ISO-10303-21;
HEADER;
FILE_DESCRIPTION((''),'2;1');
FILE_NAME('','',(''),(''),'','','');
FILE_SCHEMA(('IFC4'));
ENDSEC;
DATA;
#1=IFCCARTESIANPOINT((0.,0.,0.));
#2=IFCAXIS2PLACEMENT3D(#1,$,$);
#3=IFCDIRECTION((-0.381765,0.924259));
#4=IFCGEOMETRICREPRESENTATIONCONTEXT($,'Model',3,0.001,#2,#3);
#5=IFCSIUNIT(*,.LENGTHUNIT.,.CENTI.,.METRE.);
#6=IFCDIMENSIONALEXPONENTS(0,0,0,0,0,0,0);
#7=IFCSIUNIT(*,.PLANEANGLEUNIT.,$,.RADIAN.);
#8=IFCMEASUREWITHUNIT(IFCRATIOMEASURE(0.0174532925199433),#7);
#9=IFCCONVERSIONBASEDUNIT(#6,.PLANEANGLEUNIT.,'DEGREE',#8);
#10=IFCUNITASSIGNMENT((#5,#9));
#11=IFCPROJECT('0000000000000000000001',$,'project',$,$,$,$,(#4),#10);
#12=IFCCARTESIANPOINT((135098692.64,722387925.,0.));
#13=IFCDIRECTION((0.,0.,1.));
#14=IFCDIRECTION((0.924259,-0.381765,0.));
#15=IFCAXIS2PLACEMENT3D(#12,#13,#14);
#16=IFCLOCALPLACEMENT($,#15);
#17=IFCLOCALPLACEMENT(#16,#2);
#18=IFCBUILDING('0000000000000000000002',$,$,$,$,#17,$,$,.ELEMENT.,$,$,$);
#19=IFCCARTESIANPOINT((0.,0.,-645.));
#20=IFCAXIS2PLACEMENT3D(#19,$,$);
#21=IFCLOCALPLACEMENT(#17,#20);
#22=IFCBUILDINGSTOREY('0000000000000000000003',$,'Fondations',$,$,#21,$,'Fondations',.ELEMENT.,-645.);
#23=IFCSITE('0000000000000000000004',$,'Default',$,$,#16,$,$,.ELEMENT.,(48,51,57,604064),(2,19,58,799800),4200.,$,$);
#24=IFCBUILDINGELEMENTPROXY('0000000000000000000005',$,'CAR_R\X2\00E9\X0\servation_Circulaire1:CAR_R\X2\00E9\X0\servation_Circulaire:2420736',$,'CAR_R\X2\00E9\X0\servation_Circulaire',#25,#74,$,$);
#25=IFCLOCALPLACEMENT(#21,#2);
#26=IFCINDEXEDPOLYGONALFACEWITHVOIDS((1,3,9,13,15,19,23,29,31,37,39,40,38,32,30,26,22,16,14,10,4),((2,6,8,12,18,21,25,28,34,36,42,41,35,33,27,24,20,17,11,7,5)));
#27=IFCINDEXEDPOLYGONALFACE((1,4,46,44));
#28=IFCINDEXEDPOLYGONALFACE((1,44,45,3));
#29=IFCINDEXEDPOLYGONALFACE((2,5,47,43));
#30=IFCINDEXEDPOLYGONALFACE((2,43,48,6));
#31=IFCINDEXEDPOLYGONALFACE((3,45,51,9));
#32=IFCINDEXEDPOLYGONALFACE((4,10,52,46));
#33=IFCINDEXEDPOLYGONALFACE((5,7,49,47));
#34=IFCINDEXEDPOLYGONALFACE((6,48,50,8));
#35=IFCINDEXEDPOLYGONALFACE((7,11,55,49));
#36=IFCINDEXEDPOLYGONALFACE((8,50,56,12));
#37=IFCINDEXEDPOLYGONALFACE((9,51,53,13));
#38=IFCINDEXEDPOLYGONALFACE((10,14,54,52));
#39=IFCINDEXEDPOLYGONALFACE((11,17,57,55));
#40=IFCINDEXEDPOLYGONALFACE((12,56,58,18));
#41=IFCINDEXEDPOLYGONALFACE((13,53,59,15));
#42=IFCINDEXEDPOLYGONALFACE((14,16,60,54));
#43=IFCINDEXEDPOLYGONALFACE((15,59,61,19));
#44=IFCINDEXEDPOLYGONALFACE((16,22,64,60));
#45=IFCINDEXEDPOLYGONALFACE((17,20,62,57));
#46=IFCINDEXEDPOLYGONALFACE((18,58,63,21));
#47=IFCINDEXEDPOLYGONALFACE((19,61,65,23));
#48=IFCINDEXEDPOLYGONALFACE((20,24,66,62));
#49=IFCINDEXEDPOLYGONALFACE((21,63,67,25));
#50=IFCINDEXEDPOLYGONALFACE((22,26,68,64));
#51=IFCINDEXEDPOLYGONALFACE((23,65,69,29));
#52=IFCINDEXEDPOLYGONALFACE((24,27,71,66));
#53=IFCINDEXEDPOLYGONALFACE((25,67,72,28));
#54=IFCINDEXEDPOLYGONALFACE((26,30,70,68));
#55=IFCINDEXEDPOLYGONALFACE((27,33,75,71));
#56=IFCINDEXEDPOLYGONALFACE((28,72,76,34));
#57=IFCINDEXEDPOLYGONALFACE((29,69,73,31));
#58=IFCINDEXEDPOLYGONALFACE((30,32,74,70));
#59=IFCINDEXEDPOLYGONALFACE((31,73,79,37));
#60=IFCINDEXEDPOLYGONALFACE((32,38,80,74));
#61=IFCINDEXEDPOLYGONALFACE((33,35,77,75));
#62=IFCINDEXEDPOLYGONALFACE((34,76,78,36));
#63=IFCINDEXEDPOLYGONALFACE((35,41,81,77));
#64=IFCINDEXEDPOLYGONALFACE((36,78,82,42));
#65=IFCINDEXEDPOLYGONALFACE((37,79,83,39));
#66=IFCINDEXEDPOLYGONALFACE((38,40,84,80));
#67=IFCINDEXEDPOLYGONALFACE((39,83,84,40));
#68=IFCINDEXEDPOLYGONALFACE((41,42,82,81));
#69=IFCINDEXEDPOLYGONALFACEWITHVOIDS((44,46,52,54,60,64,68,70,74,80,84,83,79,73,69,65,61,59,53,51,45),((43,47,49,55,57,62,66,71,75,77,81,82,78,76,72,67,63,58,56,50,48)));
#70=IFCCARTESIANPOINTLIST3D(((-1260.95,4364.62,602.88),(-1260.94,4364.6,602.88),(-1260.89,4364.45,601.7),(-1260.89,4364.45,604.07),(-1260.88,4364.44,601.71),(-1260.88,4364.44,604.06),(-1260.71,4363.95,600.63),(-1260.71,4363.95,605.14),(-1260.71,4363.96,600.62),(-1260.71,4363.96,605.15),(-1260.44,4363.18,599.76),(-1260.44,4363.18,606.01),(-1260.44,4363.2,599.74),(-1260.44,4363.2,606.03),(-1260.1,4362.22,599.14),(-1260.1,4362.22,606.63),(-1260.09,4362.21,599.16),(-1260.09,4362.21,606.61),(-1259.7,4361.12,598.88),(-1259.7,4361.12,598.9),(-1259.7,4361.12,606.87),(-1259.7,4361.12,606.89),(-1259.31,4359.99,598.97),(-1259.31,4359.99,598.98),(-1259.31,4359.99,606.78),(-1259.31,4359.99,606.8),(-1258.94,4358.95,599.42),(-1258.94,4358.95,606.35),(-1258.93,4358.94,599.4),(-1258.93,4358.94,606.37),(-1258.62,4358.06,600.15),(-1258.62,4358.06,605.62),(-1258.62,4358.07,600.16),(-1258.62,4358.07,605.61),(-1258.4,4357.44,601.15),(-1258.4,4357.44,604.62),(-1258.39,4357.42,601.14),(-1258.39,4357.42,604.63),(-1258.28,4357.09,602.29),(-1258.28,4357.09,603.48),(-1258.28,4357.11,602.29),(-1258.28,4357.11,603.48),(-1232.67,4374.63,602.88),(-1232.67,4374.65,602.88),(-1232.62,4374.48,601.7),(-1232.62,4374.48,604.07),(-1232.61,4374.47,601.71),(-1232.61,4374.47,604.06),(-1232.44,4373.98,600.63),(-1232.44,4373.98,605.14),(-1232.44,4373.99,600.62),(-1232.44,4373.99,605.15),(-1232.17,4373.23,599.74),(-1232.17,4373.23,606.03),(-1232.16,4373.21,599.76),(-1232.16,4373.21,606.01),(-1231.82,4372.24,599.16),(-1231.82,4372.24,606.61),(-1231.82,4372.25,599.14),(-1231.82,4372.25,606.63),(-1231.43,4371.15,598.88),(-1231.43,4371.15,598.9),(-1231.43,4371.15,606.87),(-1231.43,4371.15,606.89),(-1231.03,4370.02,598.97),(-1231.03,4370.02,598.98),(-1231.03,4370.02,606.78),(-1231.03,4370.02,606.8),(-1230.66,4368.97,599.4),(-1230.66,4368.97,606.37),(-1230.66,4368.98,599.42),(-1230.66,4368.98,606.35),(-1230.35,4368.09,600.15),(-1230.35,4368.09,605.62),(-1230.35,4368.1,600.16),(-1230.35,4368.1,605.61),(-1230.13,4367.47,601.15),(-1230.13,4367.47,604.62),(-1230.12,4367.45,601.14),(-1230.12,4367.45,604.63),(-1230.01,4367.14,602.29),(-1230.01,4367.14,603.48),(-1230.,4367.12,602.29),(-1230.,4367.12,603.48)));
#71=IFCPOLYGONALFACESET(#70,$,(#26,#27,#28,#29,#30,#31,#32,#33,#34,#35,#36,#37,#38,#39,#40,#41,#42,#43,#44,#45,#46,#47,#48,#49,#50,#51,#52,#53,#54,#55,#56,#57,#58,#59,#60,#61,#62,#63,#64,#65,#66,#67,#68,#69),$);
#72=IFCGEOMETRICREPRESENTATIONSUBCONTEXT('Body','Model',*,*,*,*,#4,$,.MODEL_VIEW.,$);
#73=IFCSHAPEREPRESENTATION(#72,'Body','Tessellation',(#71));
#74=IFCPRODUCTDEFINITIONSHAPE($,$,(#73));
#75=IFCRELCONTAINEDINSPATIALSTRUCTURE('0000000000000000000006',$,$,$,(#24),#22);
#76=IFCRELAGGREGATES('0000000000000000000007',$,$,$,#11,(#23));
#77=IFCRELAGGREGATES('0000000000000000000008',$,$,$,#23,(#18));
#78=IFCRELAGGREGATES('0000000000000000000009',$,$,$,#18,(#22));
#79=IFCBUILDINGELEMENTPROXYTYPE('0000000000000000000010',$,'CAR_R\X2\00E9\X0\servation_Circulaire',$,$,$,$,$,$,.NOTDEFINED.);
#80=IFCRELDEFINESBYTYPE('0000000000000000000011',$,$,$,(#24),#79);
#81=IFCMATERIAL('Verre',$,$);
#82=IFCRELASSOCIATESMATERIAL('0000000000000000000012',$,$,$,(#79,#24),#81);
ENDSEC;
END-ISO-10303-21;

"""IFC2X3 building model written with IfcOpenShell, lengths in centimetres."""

from ifc_helpers import new_model, entity, si_unit, converted_unit, direction, frame, frame_2d, origin, place, context, subcontext, project, spatial, hollow_circle, extrude, source, transform, mapped, material, type_object, type_shapes, element, save


model = new_model("IFC2X3")

# Units and contexts
model_context = context("Model", 3, precision=0.001, world=origin(), true_north=direction((-0.381765, 0.924259)))
body_context = subcontext(model_context, "Body", "Model", "MODEL_VIEW")
ifc_project = project(units=[si_unit("LENGTHUNIT", "METRE", prefix="CENTI"), converted_unit("PLANEANGLEUNIT", "DEGREE", entity("IfcRatioMeasure", 0.0174532925199433), si_unit("PLANEANGLEUNIT", "RADIAN"), dimensions=[0, 0, 0, 0, 0, 0, 0])], contexts=[model_context])

# Site, building, storey
site_placement = place(None, frame((135098692.64, 722387925.0, 0.0), z_axis=(0.0, 0.0, 1.0), x_axis=(0.924259, -0.381765, 0.0)))
site = spatial("IfcSite", under=ifc_project, at=site_placement, Name="Default", CompositionType="ELEMENT", RefLatitude=(48, 51, 57, 604064), RefLongitude=(2, 19, 58, 799800), RefElevation=4200.0)
building_placement = place(site_placement, origin())
building = spatial("IfcBuilding", under=site, at=building_placement, CompositionType="ELEMENT")
storey_placement = place(building_placement, frame((0.0, 0.0, -645.0)))
storey = spatial("IfcBuildingStorey", under=building, at=storey_placement, Name="Fondations", LongName="Fondations", CompositionType="ELEMENT", Elevation=-645.0)

# Building element proxy
ifc_material_1 = material(Name="Verre")
building_element_proxy_type_1 = type_object("IfcBuildingElementProxyType", Name="CAR_Réservation_Circulaire", PredefinedType="NOTDEFINED", material=ifc_material_1)
shared_shape_1 = source(origin(), body_context, "Body", "SweptSolid", [
    extrude(hollow_circle(Radius=4.02, WallThickness=0.02, at=frame_2d((0.0, 0.0), x_axis=(1.0, 0.0))), frame((0.0, 0.0, -30.0)), (0.0, 0.0, 1.0), 30.0),
])
type_shapes(building_element_proxy_type_1, [shared_shape_1])
proxy_1_placement = place(storey_placement, frame((-1231.33, 4370.86, 602.88), z_axis=(0.942456, 0.334331, 0.0), x_axis=(-0.334331, 0.942456, 0.0)))
element("IfcBuildingElementProxy", 1, at=proxy_1_placement, inside=storey, type_object=building_element_proxy_type_1, material=ifc_material_1, Name="CAR_Réservation_Circulaire1:CAR_Réservation_Circulaire:2420736", ObjectType="CAR_Réservation_Circulaire", context=body_context, shape_type="MappedRepresentation", body=[
    mapped(shared_shape_1, transform((0.0, 0.0, 0.0), scale=1.0)),
])

save(model, "model.ifc")
